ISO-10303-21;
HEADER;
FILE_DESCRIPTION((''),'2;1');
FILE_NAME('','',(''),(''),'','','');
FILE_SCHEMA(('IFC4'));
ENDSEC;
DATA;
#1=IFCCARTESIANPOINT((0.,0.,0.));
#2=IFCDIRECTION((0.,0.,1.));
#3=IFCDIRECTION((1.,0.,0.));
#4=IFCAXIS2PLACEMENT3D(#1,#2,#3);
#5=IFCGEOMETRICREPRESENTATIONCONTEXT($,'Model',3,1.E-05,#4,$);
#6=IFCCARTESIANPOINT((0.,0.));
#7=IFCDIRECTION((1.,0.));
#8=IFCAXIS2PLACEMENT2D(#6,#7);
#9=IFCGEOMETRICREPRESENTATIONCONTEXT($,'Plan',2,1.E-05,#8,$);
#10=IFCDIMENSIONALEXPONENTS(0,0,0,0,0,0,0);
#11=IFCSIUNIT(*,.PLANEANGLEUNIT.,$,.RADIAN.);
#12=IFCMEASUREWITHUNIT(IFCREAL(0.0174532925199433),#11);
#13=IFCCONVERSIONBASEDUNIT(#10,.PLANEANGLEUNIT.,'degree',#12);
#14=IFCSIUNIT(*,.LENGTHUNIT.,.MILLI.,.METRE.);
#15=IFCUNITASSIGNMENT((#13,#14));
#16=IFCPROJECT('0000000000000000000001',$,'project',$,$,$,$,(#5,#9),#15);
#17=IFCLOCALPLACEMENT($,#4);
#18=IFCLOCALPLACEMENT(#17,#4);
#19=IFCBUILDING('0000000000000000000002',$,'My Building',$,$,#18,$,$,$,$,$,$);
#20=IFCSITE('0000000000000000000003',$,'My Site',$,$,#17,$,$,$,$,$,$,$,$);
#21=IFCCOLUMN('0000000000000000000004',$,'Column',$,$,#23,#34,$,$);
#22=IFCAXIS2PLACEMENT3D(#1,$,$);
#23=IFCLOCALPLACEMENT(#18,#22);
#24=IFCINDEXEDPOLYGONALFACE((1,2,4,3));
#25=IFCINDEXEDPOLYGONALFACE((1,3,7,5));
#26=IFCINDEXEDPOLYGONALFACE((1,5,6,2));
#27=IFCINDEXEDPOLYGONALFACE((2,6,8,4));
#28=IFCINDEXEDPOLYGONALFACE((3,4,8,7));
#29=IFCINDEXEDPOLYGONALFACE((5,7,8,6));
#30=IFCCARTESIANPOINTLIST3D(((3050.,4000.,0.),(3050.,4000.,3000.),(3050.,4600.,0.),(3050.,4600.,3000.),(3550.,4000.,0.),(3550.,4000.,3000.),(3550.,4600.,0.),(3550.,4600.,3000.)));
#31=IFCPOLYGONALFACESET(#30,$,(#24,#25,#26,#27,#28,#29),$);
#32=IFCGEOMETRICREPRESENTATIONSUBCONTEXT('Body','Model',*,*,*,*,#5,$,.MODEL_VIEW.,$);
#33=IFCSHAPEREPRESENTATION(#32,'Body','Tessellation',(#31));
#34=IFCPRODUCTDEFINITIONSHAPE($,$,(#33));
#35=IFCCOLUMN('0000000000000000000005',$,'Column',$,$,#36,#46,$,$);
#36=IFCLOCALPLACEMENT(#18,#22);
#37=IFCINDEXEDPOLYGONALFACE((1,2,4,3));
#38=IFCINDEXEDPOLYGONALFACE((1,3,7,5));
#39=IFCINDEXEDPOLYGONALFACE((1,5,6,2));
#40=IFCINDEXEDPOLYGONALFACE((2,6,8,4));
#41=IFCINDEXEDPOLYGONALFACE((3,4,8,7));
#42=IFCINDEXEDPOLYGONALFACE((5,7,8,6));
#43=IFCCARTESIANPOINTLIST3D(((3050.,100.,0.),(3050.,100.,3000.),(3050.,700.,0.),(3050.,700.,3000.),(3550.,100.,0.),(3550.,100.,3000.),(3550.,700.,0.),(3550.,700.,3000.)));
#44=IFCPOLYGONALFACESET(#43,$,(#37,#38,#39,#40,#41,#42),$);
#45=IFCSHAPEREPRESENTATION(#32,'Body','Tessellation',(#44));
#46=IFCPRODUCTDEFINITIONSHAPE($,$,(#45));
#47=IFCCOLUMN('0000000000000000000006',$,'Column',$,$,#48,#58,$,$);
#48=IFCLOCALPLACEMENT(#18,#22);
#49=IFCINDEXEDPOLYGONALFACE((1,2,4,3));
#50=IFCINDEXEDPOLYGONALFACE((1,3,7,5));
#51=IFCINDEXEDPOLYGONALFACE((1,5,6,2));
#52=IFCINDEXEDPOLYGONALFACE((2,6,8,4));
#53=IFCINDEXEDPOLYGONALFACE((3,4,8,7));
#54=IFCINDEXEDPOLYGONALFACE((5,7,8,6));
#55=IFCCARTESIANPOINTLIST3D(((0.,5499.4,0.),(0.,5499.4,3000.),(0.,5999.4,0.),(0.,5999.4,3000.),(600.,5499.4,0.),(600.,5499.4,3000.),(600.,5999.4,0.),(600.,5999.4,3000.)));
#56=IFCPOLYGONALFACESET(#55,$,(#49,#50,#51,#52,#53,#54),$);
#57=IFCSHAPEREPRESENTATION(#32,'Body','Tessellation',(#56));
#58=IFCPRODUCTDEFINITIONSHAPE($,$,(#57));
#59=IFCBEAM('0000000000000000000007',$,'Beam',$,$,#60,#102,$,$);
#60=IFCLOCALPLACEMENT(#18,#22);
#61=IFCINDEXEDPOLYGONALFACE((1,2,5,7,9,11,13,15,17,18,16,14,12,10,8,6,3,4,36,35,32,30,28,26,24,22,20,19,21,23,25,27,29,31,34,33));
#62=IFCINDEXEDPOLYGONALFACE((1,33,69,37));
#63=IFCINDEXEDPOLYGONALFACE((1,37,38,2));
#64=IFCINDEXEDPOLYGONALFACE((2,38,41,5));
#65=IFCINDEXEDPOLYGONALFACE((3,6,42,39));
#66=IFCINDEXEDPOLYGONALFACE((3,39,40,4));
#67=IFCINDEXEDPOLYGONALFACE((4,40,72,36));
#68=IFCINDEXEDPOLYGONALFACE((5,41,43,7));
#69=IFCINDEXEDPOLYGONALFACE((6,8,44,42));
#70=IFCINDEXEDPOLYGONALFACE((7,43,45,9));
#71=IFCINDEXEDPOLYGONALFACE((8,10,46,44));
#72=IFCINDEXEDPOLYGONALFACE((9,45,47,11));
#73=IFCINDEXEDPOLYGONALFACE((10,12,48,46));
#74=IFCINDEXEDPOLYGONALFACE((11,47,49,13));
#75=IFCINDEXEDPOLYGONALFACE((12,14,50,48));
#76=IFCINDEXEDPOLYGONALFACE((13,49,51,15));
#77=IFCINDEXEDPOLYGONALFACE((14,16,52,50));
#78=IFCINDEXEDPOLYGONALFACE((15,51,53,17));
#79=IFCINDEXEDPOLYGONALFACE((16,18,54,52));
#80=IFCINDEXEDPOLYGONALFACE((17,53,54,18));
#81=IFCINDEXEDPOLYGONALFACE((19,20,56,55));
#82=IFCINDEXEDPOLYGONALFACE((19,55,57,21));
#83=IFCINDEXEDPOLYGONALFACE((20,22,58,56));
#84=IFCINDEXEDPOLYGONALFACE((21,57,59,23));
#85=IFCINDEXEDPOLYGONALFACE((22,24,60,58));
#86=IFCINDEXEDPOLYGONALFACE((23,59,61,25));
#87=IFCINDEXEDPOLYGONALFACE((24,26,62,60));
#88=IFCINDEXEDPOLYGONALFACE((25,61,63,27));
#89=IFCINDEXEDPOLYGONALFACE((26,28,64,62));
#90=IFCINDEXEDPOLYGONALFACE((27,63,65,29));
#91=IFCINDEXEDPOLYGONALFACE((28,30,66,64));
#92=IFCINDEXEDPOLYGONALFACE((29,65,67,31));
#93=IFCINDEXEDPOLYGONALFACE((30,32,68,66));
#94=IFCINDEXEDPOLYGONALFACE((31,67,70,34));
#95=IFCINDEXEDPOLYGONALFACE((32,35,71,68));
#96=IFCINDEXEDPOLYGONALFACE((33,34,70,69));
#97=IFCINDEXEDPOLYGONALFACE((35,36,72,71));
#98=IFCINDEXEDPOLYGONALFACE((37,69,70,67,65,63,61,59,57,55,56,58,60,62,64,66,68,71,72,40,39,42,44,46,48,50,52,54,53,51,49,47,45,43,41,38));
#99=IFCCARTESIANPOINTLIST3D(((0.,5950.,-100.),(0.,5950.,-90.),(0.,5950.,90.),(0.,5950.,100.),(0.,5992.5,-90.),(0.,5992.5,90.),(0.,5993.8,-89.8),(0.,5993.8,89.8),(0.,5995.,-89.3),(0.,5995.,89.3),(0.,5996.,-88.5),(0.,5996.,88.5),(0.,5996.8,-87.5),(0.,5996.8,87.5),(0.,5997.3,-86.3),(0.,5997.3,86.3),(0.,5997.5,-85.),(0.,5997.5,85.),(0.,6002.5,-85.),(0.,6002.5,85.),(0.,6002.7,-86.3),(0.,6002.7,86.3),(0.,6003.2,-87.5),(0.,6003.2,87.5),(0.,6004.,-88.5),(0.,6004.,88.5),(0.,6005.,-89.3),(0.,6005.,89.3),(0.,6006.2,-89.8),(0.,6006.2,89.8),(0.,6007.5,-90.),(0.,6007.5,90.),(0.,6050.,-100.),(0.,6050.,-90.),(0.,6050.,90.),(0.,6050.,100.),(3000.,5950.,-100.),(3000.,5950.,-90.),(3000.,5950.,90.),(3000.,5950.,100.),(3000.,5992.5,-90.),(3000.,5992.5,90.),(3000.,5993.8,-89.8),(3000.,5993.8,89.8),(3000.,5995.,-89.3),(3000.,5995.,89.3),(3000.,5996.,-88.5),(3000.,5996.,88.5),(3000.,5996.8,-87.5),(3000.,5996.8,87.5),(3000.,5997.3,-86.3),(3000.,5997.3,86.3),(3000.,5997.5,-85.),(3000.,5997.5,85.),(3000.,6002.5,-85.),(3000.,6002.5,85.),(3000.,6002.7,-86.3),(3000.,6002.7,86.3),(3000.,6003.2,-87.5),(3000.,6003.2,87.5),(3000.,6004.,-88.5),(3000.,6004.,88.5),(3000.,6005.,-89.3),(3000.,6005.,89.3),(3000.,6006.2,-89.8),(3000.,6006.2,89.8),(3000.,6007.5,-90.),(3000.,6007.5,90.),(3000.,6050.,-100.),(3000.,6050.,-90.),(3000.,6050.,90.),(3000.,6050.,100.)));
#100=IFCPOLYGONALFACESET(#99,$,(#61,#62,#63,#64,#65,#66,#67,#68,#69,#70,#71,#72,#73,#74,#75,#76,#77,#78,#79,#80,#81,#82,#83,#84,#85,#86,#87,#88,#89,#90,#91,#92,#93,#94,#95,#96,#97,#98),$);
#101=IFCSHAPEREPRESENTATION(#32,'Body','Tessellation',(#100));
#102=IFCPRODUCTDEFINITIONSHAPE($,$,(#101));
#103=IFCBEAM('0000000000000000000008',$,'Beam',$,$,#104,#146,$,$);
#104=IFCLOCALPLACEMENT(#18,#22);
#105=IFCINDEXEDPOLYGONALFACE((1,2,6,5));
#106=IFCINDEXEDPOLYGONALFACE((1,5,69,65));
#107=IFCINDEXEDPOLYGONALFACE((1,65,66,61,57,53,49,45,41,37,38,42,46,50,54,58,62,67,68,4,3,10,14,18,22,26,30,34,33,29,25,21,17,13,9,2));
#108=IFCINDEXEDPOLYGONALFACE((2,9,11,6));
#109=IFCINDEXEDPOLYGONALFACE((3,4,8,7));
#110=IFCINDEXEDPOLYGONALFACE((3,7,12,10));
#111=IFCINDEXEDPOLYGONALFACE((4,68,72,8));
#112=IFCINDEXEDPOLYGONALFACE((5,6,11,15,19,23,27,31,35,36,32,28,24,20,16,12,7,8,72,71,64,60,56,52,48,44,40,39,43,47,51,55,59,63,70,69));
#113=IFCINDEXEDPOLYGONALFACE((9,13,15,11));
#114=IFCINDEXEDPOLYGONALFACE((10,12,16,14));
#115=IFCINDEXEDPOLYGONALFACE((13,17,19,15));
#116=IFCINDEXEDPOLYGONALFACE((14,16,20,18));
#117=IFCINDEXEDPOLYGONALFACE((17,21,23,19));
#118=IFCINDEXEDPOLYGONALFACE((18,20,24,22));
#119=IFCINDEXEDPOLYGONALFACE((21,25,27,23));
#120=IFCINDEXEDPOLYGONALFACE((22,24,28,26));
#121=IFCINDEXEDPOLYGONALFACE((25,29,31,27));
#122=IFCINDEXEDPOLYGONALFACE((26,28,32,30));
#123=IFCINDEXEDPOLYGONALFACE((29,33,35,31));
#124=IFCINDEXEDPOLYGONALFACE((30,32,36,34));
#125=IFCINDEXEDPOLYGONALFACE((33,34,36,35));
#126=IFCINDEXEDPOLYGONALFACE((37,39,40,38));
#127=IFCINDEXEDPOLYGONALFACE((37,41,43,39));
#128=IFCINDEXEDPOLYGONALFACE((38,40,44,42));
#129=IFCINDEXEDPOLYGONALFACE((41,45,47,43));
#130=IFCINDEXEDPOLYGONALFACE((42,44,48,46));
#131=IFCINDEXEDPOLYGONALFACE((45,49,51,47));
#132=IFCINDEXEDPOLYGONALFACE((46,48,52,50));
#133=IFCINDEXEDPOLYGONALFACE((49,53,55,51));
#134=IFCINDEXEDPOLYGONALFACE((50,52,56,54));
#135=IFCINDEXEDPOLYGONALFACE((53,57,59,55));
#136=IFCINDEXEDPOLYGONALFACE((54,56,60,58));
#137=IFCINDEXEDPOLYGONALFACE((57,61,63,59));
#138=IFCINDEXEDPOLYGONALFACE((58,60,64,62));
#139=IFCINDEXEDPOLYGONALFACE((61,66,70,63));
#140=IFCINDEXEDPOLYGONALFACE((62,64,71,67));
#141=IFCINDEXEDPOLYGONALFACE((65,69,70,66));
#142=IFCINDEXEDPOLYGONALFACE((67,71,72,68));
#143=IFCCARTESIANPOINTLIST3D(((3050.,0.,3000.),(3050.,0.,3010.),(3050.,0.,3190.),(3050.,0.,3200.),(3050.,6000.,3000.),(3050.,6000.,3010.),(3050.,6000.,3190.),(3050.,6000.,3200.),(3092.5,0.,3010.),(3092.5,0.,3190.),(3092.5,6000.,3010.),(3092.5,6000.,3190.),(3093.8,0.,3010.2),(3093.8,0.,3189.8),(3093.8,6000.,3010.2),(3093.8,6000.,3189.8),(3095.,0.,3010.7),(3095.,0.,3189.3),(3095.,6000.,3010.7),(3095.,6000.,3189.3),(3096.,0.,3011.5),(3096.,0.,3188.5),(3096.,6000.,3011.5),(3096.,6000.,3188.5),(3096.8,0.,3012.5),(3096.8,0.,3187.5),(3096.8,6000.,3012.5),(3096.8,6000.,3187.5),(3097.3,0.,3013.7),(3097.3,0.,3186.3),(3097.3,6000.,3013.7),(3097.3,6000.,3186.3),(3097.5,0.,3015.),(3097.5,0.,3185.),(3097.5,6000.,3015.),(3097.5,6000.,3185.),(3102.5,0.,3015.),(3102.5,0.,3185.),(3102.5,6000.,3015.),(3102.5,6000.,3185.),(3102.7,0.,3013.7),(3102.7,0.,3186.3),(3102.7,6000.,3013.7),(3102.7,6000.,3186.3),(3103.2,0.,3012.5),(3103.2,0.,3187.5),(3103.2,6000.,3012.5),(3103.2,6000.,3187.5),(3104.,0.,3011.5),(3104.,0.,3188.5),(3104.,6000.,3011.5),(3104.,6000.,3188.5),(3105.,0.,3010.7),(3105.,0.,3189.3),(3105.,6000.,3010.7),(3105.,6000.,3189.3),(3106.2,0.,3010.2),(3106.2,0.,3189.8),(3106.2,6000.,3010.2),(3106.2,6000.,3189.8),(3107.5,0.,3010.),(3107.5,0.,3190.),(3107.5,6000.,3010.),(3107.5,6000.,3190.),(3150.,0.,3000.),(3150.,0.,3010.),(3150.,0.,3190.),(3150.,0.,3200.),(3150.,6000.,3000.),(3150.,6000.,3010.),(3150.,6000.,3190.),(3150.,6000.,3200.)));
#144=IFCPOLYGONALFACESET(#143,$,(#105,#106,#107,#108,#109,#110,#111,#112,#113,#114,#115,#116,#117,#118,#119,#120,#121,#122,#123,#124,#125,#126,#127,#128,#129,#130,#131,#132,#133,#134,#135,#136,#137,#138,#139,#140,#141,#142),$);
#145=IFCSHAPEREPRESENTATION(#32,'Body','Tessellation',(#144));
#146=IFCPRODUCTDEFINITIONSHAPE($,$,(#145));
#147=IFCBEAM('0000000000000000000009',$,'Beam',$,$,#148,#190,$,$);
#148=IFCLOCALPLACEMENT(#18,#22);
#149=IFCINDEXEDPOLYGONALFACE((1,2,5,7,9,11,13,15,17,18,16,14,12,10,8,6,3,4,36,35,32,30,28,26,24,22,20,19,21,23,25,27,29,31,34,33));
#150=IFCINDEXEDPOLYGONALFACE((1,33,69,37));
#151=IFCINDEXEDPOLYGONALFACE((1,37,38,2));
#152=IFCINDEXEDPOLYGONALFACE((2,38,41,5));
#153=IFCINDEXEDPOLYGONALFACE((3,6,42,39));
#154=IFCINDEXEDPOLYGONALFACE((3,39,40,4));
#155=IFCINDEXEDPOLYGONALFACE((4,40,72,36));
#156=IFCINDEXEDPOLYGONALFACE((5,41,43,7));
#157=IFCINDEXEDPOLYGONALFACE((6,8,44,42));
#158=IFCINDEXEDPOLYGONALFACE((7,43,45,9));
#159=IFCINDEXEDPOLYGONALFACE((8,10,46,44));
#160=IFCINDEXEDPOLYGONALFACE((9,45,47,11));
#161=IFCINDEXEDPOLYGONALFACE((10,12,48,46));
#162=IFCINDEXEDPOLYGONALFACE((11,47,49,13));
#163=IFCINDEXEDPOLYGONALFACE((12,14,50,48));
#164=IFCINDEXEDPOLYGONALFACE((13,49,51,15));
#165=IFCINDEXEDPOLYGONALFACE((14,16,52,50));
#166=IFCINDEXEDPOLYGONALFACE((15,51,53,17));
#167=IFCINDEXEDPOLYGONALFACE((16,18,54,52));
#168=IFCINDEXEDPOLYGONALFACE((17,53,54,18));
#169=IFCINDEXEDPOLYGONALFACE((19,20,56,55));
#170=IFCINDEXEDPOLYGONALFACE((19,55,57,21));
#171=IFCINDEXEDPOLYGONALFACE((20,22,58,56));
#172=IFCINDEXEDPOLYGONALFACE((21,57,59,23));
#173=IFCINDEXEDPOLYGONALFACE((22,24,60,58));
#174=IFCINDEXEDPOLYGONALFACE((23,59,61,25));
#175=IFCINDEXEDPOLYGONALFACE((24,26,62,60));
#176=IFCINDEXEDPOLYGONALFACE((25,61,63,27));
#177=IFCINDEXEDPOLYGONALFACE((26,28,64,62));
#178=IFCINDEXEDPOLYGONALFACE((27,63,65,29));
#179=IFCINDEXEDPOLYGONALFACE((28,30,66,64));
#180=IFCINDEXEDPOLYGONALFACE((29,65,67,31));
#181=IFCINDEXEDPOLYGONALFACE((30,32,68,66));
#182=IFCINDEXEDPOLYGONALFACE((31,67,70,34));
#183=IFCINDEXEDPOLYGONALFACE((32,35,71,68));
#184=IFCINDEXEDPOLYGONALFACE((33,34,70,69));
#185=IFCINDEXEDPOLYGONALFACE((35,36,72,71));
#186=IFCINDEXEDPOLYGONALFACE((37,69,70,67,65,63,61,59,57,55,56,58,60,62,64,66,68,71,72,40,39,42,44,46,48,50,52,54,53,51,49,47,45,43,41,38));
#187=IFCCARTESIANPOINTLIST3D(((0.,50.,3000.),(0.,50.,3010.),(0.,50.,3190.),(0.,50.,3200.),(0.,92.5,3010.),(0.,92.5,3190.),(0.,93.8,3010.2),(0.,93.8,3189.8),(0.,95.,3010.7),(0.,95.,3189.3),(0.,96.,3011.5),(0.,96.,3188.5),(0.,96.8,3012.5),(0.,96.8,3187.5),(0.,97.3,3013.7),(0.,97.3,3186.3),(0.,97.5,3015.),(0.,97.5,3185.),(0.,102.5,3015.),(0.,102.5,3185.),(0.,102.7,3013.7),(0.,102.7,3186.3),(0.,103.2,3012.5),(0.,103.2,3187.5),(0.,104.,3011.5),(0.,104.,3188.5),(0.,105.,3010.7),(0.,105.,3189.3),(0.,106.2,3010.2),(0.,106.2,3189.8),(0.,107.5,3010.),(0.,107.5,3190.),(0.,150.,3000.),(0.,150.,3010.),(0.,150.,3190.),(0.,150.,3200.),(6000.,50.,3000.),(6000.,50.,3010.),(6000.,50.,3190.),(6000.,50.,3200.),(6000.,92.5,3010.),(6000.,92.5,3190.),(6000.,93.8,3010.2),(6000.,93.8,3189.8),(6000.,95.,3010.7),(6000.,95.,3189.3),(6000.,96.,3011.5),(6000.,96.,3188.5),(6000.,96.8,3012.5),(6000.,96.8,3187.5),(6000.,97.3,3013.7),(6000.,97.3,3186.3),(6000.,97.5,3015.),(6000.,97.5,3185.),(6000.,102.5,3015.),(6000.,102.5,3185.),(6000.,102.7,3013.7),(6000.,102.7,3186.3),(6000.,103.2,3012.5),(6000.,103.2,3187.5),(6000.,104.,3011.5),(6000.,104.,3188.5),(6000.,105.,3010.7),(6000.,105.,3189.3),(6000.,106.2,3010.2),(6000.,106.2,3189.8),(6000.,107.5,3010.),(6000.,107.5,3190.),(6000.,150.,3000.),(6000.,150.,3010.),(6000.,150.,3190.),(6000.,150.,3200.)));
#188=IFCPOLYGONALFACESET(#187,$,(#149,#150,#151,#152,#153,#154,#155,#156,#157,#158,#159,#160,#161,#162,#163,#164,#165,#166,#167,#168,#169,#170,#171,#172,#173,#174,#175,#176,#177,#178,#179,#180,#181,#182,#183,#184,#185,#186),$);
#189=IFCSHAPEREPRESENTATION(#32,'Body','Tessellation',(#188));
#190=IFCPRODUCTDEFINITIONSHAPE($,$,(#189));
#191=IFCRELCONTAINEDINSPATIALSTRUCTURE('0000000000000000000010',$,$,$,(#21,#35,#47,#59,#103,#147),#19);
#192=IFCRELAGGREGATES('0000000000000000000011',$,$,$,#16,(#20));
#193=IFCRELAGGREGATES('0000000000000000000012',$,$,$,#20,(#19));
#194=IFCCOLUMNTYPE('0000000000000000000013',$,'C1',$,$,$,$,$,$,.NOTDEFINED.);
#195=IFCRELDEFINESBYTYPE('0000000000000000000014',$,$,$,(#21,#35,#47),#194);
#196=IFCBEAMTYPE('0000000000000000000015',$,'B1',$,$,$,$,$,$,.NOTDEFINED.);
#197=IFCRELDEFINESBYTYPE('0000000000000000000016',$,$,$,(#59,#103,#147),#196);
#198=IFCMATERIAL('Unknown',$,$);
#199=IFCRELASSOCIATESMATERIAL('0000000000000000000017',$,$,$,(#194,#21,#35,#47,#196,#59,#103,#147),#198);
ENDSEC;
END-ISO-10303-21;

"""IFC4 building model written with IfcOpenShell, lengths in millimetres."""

from ifc_helpers import new_model, entity, si_unit, converted_unit, frame, origin_with_axes, origin_2d_with_axis, place, context, subcontext, project, spatial, rectangle, i_section, extrude, material, material_profile, profile_set, profile_usage, type_object, element, save


model = new_model("IFC4")

# Units and contexts
model_context = context("Model", 3, precision=1e-05, world=origin_with_axes())
plan_context = context("Plan", 2, precision=1e-05, world=origin_2d_with_axis())
body_context = subcontext(model_context, "Body", "Model", "MODEL_VIEW")
ifc_project = project(units=[converted_unit("PLANEANGLEUNIT", "degree", entity("IfcReal", 0.0174532925199433), si_unit("PLANEANGLEUNIT", "RADIAN"), dimensions=[0, 0, 0, 0, 0, 0, 0]), si_unit("LENGTHUNIT", "METRE", prefix="MILLI")], contexts=[model_context, plan_context])

# Site, building
site_placement = place(None, origin_with_axes())
site = spatial("IfcSite", under=ifc_project, at=site_placement, Name="My Site")
building_placement = place(site_placement, origin_with_axes())
building = spatial("IfcBuilding", under=site, at=building_placement, Name="My Building")

# Columns
ifc_material_1 = material(Name="Unknown")
ifc_material_profile_1 = material_profile(ifc_material_1, rectangle(XDim=500.0, YDim=600.0))
ifc_profile_set_1 = profile_set([ifc_material_profile_1])
ifc_profile_usage_1 = profile_usage(ifc_profile_set_1, cardinal=5)
column_type = type_object("IfcColumnType", Name="C1", PredefinedType="NOTDEFINED", material=ifc_profile_set_1)
column_1_placement = place(building_placement, frame((3300.0, 4300.0, 0.0), z_axis=(0.0, 0.0, 1.0), x_axis=(1.0, 0.0, 0.0)))
element("IfcColumn", 1, at=column_1_placement, inside=building, type_object=column_type, material=ifc_profile_usage_1, Name="Column", context=body_context, shape_type="SweptSolid", body=[
    extrude(rectangle(XDim=500.0, YDim=600.0), origin_with_axes(), (0.0, 0.0, 1.0), 3000.0),
])
ifc_profile_usage_2 = profile_usage(ifc_profile_set_1)
column_2_placement = place(building_placement, frame((3300.0, 400.0, 0.0), z_axis=(0.0, 0.0, 1.0), x_axis=(1.0, 0.0, 0.0)))
element("IfcColumn", 2, at=column_2_placement, inside=building, type_object=column_type, material=ifc_profile_usage_2, Name="Column", context=body_context, shape_type="SweptSolid", body=[
    extrude(rectangle(XDim=500.0, YDim=600.0), origin_with_axes(), (0.0, 0.0, 1.0), 3000.0),
])
ifc_profile_usage_3 = profile_usage(ifc_profile_set_1, cardinal=5)
column_3_placement = place(building_placement, frame((300.0, 5749.4, 0.0), z_axis=(0.0, 0.0, 1.0), x_axis=(0.0, 1.0, 0.0)))
element("IfcColumn", 3, at=column_3_placement, inside=building, type_object=column_type, material=ifc_profile_usage_3, Name="Column", context=body_context, shape_type="SweptSolid", body=[
    extrude(rectangle(XDim=500.0, YDim=600.0), origin_with_axes(), (0.0, 0.0, 1.0), 3000.0),
])

# Beams
ifc_material_profile_2 = material_profile(ifc_material_1, i_section(OverallWidth=100.0, OverallDepth=200.0, WebThickness=5.0, FlangeThickness=10.0, FilletRadius=5.0))
ifc_profile_set_2 = profile_set([ifc_material_profile_2])
ifc_profile_usage_4 = profile_usage(ifc_profile_set_2, cardinal=5)
beam_type = type_object("IfcBeamType", Name="B1", PredefinedType="NOTDEFINED", material=ifc_profile_set_2)
beam_1_placement = place(building_placement, frame((0.0, 6000.0, 0.0), z_axis=(1.0, 0.0, 0.0), x_axis=(0.0, 1.0, 0.0)))
element("IfcBeam", 4, at=beam_1_placement, inside=building, type_object=beam_type, material=ifc_profile_usage_4, Name="Beam", context=body_context, shape_type="SweptSolid", body=[
    extrude(i_section(OverallWidth=100.0, OverallDepth=200.0, WebThickness=5.0, FlangeThickness=10.0, FilletRadius=5.0), origin_with_axes(), (0.0, 0.0, 1.0), 3000.0),
])
ifc_profile_usage_5 = profile_usage(ifc_profile_set_2, cardinal=5)
beam_2_placement = place(building_placement, frame((3100.0, 0.0, 3100.0), z_axis=(0.0, 1.0, 0.0), x_axis=(-1.0, 0.0, 0.0)))
element("IfcBeam", 5, at=beam_2_placement, inside=building, type_object=beam_type, material=ifc_profile_usage_5, Name="Beam", context=body_context, shape_type="SweptSolid", body=[
    extrude(i_section(OverallWidth=100.0, OverallDepth=200.0, WebThickness=5.0, FlangeThickness=10.0, FilletRadius=5.0), origin_with_axes(), (0.0, 0.0, 1.0), 6000.0),
])
ifc_profile_usage_6 = profile_usage(ifc_profile_set_2, cardinal=5)
beam_3_placement = place(building_placement, frame((0.0, 100.0, 3100.0), z_axis=(1.0, 0.0, 0.0), x_axis=(0.0, 1.0, 0.0)))
element("IfcBeam", 6, at=beam_3_placement, inside=building, type_object=beam_type, material=ifc_profile_usage_6, Name="Beam", context=body_context, shape_type="SweptSolid", body=[
    extrude(i_section(OverallWidth=100.0, OverallDepth=200.0, WebThickness=5.0, FlangeThickness=10.0, FilletRadius=5.0), origin_with_axes(), (0.0, 0.0, 1.0), 6000.0),
])

save(model, "model.ifc")
